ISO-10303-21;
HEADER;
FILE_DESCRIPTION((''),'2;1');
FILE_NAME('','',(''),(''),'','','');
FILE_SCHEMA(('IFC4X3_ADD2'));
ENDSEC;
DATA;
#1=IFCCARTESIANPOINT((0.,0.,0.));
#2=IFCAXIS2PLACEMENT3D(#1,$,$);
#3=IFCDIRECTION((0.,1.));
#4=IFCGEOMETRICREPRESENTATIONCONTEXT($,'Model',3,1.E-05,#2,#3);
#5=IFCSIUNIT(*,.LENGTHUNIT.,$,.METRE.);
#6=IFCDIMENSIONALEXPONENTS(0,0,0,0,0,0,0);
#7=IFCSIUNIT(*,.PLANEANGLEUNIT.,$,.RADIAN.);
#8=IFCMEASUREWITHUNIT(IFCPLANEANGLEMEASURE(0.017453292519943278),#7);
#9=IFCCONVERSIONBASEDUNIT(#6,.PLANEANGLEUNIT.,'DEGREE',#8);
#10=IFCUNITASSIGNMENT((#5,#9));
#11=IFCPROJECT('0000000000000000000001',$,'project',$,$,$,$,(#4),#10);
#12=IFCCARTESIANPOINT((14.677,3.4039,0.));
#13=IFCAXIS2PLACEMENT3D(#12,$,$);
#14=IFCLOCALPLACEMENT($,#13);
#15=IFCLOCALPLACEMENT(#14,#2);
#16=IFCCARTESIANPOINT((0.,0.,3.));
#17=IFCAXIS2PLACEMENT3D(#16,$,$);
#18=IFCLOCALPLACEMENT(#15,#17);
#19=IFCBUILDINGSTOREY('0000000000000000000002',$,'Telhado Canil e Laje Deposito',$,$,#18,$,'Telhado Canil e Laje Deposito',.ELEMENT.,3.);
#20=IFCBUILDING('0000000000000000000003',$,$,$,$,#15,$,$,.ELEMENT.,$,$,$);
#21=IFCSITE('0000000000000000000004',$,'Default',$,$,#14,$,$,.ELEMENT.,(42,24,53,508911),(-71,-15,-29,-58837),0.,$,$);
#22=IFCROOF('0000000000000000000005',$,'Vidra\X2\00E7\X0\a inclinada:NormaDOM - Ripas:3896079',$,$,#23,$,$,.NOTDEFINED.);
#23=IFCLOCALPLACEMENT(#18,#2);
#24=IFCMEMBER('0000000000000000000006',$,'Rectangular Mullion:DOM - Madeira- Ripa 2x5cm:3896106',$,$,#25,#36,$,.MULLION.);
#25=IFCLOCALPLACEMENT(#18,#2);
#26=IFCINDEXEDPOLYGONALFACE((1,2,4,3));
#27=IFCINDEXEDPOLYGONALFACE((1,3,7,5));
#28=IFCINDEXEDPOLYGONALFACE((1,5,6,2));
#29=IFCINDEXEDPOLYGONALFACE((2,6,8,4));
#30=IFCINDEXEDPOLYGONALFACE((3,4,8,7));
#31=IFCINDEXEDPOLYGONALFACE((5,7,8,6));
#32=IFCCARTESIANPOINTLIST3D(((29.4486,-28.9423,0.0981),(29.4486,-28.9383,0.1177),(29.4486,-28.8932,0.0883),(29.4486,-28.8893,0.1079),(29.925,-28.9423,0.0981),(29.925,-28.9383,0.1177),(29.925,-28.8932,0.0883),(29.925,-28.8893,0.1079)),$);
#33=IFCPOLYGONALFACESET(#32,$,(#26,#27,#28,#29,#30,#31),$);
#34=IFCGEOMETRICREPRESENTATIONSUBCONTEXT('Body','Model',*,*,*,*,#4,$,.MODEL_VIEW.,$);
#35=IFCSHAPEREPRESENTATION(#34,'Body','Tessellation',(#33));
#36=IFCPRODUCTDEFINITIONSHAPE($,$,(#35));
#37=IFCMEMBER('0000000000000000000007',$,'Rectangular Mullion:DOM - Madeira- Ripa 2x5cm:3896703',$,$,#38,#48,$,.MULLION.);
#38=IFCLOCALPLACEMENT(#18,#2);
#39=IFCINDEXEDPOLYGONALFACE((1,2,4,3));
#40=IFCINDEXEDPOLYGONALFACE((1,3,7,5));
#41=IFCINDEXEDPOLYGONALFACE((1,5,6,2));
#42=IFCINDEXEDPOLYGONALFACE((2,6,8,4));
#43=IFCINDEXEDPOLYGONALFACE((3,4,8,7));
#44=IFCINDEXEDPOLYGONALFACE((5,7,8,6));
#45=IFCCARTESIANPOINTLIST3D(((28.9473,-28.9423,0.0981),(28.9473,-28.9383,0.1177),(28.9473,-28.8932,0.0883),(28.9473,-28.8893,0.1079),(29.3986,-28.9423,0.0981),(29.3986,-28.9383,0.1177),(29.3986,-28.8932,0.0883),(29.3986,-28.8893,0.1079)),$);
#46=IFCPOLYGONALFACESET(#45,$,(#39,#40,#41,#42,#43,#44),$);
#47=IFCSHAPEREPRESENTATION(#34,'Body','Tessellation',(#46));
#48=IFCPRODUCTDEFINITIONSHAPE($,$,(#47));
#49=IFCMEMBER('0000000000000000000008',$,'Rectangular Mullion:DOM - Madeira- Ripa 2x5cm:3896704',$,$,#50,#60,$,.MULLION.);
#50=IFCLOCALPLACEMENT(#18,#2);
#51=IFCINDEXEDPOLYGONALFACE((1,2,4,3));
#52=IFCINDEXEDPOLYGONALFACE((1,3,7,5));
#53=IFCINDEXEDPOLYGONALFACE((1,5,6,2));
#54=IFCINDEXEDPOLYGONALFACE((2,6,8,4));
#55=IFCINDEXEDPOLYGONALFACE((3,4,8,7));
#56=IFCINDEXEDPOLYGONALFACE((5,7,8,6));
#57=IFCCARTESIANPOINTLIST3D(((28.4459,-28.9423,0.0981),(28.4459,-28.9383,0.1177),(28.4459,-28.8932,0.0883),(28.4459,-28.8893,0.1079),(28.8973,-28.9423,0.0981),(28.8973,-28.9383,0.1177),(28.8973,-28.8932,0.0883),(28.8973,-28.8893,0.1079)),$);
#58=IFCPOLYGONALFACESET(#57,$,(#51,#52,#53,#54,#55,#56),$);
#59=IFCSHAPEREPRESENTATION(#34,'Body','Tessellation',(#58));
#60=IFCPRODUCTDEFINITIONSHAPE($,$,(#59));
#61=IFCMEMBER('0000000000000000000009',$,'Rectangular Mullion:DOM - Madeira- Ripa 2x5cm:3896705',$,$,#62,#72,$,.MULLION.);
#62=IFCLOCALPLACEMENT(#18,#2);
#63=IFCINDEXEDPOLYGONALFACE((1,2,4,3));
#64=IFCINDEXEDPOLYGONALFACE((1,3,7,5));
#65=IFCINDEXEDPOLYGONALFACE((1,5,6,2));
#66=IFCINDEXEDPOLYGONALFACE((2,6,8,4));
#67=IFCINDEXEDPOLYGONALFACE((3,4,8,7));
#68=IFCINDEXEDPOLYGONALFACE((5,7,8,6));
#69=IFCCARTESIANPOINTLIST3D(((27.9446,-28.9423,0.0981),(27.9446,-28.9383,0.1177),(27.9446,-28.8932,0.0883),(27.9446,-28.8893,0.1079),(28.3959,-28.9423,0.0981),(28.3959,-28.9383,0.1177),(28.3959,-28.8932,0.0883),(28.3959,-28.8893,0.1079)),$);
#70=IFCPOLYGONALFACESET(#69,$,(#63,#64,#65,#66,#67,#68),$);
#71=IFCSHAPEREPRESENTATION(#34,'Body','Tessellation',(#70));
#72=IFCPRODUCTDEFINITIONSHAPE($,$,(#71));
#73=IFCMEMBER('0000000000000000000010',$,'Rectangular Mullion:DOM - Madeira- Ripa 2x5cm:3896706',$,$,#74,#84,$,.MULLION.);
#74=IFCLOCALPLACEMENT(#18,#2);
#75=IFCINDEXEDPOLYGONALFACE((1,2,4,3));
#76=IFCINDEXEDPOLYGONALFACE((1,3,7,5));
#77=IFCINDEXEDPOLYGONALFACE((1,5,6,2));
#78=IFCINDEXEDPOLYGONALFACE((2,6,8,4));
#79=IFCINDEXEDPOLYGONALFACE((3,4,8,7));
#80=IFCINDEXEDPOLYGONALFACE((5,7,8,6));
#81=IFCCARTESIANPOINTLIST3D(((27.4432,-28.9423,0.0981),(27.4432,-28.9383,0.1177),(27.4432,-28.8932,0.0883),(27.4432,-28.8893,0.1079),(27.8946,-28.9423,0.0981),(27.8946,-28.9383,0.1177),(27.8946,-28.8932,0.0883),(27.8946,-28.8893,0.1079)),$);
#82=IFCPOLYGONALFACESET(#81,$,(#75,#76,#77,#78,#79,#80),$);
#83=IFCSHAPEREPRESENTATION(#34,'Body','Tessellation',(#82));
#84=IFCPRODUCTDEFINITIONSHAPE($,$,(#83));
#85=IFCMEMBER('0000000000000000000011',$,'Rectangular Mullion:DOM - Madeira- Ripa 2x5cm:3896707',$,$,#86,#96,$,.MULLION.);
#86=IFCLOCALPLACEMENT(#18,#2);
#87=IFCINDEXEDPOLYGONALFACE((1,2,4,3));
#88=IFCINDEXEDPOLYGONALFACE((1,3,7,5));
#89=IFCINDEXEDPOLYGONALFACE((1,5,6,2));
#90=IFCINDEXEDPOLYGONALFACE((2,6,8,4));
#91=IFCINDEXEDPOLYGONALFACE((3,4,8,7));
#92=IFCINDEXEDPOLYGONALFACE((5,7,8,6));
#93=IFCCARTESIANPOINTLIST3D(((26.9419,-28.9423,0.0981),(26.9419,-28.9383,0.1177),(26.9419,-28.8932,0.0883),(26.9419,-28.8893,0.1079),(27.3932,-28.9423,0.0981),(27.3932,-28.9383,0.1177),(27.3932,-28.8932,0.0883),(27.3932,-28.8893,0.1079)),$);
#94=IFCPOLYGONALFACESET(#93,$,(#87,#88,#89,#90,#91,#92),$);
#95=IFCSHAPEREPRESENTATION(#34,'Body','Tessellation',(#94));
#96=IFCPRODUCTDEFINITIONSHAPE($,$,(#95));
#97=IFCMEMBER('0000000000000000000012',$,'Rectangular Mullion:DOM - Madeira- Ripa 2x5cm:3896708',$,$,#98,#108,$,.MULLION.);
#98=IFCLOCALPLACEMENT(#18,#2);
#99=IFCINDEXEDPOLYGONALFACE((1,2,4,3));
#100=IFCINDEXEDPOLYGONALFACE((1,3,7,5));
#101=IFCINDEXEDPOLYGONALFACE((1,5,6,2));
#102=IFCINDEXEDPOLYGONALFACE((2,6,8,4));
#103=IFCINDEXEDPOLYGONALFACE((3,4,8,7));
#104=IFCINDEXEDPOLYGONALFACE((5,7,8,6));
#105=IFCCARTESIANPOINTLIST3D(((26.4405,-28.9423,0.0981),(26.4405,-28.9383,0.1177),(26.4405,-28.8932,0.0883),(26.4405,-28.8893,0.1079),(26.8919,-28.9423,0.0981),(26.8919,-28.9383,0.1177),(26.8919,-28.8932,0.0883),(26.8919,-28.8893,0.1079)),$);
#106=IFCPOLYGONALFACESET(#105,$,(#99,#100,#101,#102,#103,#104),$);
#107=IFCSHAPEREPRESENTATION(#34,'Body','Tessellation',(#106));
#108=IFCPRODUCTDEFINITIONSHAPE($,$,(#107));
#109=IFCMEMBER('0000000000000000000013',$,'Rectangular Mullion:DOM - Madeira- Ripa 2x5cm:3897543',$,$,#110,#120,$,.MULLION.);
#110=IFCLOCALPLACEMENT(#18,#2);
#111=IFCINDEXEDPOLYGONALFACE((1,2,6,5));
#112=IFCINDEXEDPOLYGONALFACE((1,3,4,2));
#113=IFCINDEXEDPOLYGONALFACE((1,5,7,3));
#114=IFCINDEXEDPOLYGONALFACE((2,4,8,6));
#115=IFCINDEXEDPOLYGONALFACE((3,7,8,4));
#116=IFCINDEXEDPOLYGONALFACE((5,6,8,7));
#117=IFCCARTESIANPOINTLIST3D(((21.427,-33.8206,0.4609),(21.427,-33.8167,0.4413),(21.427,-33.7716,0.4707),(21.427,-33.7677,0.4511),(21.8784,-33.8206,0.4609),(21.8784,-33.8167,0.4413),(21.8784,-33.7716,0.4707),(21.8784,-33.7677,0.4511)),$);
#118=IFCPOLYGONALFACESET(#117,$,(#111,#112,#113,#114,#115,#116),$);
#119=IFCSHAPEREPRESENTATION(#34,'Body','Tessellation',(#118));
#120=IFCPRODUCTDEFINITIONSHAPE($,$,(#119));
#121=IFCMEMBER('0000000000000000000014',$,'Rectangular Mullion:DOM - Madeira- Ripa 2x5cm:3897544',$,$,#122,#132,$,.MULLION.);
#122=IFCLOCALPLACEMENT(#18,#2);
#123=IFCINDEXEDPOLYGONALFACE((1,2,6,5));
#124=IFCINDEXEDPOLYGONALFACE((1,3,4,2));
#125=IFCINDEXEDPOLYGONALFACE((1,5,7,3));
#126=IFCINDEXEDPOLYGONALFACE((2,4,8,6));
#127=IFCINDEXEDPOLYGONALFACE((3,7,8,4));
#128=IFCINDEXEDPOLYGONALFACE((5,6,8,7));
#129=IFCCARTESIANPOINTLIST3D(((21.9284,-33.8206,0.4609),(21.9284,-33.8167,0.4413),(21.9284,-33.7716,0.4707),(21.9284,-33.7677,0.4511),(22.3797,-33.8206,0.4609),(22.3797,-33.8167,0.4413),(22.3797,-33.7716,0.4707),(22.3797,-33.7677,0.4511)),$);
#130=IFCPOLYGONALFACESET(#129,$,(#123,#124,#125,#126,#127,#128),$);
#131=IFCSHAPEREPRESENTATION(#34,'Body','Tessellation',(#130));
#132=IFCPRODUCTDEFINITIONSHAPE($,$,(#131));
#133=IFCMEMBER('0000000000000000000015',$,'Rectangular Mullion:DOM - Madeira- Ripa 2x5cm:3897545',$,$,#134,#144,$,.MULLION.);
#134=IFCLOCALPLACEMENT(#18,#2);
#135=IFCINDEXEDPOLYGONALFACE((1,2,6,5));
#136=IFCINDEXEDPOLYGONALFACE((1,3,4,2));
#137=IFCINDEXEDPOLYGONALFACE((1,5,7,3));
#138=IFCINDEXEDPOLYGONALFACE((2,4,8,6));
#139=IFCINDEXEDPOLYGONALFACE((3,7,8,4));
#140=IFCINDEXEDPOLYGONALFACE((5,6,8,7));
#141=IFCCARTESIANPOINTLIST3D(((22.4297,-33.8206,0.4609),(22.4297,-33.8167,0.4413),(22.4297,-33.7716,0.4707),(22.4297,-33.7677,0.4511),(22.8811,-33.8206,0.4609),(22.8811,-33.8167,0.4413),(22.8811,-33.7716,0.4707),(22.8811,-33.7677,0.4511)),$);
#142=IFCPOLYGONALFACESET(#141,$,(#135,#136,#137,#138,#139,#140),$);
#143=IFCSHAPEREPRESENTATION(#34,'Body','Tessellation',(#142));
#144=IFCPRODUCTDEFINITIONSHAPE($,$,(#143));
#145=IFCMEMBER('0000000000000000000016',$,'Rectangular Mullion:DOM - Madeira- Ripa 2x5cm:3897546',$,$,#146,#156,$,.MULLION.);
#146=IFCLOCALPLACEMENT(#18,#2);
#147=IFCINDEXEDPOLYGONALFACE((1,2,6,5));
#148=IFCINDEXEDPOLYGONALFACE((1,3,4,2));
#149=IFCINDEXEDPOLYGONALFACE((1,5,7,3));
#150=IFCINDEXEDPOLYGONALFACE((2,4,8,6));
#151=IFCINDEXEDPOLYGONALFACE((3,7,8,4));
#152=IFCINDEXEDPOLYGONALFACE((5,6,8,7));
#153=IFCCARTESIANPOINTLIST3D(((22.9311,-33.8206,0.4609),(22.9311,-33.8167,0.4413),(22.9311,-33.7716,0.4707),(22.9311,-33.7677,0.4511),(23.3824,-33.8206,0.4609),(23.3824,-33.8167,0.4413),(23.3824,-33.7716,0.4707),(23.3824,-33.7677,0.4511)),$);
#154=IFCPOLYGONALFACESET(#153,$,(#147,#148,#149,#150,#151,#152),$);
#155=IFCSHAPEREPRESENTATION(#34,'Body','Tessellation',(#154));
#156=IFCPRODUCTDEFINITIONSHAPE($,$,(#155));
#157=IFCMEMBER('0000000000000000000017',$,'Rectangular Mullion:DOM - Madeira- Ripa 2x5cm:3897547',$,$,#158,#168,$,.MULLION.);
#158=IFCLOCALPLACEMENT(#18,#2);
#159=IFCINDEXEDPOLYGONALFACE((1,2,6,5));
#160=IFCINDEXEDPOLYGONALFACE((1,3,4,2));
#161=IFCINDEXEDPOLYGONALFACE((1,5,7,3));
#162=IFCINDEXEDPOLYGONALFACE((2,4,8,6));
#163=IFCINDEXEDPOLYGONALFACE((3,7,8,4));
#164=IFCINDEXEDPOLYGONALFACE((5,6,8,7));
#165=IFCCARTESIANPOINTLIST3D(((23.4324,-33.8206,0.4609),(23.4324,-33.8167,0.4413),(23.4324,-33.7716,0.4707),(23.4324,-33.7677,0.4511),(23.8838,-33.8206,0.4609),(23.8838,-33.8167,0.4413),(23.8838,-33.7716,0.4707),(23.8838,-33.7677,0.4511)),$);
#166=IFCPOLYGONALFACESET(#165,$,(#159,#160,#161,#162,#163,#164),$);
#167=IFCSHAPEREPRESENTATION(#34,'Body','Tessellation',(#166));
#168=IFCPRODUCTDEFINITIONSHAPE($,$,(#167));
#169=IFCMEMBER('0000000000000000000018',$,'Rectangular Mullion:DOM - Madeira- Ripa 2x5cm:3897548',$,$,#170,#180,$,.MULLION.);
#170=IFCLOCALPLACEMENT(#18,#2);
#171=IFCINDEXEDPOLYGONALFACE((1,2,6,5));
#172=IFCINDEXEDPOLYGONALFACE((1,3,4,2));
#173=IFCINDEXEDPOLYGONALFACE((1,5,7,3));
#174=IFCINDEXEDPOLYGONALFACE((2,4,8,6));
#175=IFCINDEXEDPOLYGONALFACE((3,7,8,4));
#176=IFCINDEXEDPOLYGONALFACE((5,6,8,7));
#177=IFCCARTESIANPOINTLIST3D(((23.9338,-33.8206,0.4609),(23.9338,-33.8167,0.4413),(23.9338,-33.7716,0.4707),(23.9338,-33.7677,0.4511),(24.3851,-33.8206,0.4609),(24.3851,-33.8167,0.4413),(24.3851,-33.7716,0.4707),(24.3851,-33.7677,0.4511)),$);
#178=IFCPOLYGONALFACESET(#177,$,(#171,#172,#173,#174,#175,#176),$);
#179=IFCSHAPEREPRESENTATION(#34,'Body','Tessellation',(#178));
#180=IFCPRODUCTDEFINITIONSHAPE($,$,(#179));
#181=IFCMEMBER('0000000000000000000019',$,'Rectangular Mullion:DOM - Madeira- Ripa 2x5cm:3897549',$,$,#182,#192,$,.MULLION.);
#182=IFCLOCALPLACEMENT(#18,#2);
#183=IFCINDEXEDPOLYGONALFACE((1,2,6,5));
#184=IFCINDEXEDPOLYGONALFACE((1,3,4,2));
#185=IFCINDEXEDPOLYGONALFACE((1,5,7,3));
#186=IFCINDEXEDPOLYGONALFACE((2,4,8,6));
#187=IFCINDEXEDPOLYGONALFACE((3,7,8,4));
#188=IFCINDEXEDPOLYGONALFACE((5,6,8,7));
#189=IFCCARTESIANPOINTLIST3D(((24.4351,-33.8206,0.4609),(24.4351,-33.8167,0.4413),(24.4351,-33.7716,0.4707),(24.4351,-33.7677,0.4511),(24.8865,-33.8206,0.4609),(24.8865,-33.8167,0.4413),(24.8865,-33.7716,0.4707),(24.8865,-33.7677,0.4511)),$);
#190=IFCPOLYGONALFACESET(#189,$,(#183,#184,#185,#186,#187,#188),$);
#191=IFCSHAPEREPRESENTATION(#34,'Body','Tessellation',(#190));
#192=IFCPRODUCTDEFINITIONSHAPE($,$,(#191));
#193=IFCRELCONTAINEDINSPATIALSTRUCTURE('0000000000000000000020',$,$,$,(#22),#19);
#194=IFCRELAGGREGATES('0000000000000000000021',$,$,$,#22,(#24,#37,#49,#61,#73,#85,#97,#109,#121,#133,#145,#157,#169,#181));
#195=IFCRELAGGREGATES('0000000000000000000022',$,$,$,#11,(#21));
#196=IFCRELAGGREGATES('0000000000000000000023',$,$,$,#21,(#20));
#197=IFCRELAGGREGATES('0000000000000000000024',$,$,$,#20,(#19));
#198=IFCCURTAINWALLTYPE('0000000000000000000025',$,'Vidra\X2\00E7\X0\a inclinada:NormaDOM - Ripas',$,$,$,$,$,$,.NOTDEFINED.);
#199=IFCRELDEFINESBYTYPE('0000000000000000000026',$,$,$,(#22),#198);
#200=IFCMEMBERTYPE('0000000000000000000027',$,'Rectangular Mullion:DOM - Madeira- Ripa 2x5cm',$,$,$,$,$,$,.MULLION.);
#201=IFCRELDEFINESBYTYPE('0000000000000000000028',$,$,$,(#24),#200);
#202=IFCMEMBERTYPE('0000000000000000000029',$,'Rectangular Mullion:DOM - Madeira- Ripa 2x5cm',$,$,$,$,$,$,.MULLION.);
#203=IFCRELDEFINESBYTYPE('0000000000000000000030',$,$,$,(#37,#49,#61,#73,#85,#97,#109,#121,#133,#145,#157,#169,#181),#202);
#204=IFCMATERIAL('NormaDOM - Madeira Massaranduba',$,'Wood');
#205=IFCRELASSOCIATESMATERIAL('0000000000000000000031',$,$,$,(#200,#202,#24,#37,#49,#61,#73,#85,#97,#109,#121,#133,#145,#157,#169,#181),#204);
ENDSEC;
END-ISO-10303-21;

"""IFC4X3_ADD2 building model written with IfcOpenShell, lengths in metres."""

from ifc_helpers import new_model, entity, si_unit, converted_unit, direction, frame, origin, origin_2d_with_axis, place, context, subcontext, project, spatial, rectangle, extrude, source, transform, mapped, material, material_profile, profile_set, profile_usage, type_object, type_shapes, element, aggregate, save


model = new_model("IFC4X3_ADD2")

# Units and contexts
model_context = context("Model", 3, precision=1e-05, world=origin(), true_north=direction((0.0, 1.0)))
body_context = subcontext(model_context, "Body", "Model", "MODEL_VIEW")
ifc_project = project(units=[si_unit("LENGTHUNIT", "METRE"), converted_unit("PLANEANGLEUNIT", "DEGREE", entity("IfcPlaneAngleMeasure", 0.017453292519943278), si_unit("PLANEANGLEUNIT", "RADIAN"), dimensions=[0, 0, 0, 0, 0, 0, 0])], contexts=[model_context])

# Site, building, storey
site_placement = place(None, frame((14.677, 3.4039, 0.0)))
site = spatial("IfcSite", under=ifc_project, at=site_placement, Name="Default", CompositionType="ELEMENT", RefLatitude=(42, 24, 53, 508911), RefLongitude=(-71, -15, -29, -58837), RefElevation=0.0)
building_placement = place(site_placement, origin())
building = spatial("IfcBuilding", under=site, at=building_placement, CompositionType="ELEMENT")
storey_placement = place(building_placement, frame((0.0, 0.0, 3.0)))
storey = spatial("IfcBuildingStorey", under=building, at=storey_placement, Name="Telhado Canil e Laje Deposito", LongName="Telhado Canil e Laje Deposito", CompositionType="ELEMENT", Elevation=3.0)

# Roof, members
curtain_wall_type = type_object("IfcCurtainWallType", Name="Vidraça inclinada:NormaDOM - Ripas", PredefinedType="NOTDEFINED")
roof_placement = place(storey_placement, frame((0.0, 0.0, -3.0)))
roof = element("IfcRoof", 1, at=roof_placement, inside=storey, type_object=curtain_wall_type, Name="Vidraça inclinada:NormaDOM - Ripas:3896079", PredefinedType="NOTDEFINED")
ifc_material = material(Name="NormaDOM - Madeira Massaranduba", Category="Wood")
ifc_material_profile_1 = material_profile(ifc_material, rectangle(XDim=0.05, YDim=0.02, at=origin_2d_with_axis()), Name="DOM - Madeira- Ripa 2x5cm")
ifc_profile_set_1 = profile_set([ifc_material_profile_1], Name="DOM - Madeira- Ripa 2x5cm")
ifc_profile_usage_1 = profile_usage(ifc_profile_set_1)
member_type_1 = type_object("IfcMemberType", Name="Rectangular Mullion:DOM - Madeira- Ripa 2x5cm", PredefinedType="MULLION", material=ifc_profile_set_1)
shared_shape_1 = source(origin(), body_context, "Body", "SweptSolid", [
    extrude(rectangle(XDim=0.05, YDim=0.02, at=origin_2d_with_axis()), frame((0.025, 0.01, -0.4764), z_axis=(0.0, 0.0, 1.0), x_axis=(-1.0, 0.0, 0.0)), (0.0, 0.0, 1.0), 0.4764),
])
type_shapes(member_type_1, [shared_shape_1])
member_1_placement = place(roof_placement, frame((29.925, -28.8893, 3.1079), z_axis=(1.0, 0.0, 0.0), x_axis=(0.0, -0.980581, 0.196116)))
member_1 = element("IfcMember", 2, at=member_1_placement, type_object=member_type_1, material=ifc_profile_usage_1, Name="Rectangular Mullion:DOM - Madeira- Ripa 2x5cm:3896106", PredefinedType="MULLION", context=body_context, shape_type="MappedRepresentation", body=[
    mapped(shared_shape_1, transform((0.0, 0.0, 0.0), scale=1.0)),
])
member_type_2 = type_object("IfcMemberType", Name="Rectangular Mullion:DOM - Madeira- Ripa 2x5cm", PredefinedType="MULLION", material=ifc_profile_set_1)
shared_shape_2 = source(origin(), body_context, "Body", "SweptSolid", [
    extrude(rectangle(XDim=0.05, YDim=0.02, at=origin_2d_with_axis()), frame((0.025, 0.01, -0.4514), z_axis=(0.0, 0.0, 1.0), x_axis=(-1.0, 0.0, 0.0)), (0.0, 0.0, 1.0), 0.4514),
])
type_shapes(member_type_2, [shared_shape_2])
member_2_placement = place(roof_placement, frame((29.3986, -28.8893, 3.1079), z_axis=(1.0, 0.0, 0.0), x_axis=(0.0, -0.980581, 0.196116)))
member_2 = element("IfcMember", 3, at=member_2_placement, type_object=member_type_2, material=ifc_profile_usage_1, Name="Rectangular Mullion:DOM - Madeira- Ripa 2x5cm:3896703", PredefinedType="MULLION", context=body_context, shape_type="MappedRepresentation", body=[
    mapped(shared_shape_2, transform((0.0, 0.0, 0.0), scale=1.0)),
])
member_3_placement = place(roof_placement, frame((28.8973, -28.8893, 3.1079), z_axis=(1.0, 0.0, 0.0), x_axis=(0.0, -0.980581, 0.196116)))
member_3 = element("IfcMember", 4, at=member_3_placement, type_object=member_type_2, material=ifc_profile_usage_1, Name="Rectangular Mullion:DOM - Madeira- Ripa 2x5cm:3896704", PredefinedType="MULLION", context=body_context, shape_type="MappedRepresentation", body=[
    mapped(shared_shape_2, transform((0.0, 0.0, 0.0), scale=1.0)),
])
member_4_placement = place(roof_placement, frame((28.3959, -28.8893, 3.1079), z_axis=(1.0, 0.0, 0.0), x_axis=(0.0, -0.980581, 0.196116)))
member_4 = element("IfcMember", 5, at=member_4_placement, type_object=member_type_2, material=ifc_profile_usage_1, Name="Rectangular Mullion:DOM - Madeira- Ripa 2x5cm:3896705", PredefinedType="MULLION", context=body_context, shape_type="MappedRepresentation", body=[
    mapped(shared_shape_2, transform((0.0, 0.0, 0.0), scale=1.0)),
])
member_5_placement = place(roof_placement, frame((27.8946, -28.8893, 3.1079), z_axis=(1.0, 0.0, 0.0), x_axis=(0.0, -0.980581, 0.196116)))
member_5 = element("IfcMember", 6, at=member_5_placement, type_object=member_type_2, material=ifc_profile_usage_1, Name="Rectangular Mullion:DOM - Madeira- Ripa 2x5cm:3896706", PredefinedType="MULLION", context=body_context, shape_type="MappedRepresentation", body=[
    mapped(shared_shape_2, transform((0.0, 0.0, 0.0), scale=1.0)),
])
member_6_placement = place(roof_placement, frame((27.3932, -28.8893, 3.1079), z_axis=(1.0, 0.0, 0.0), x_axis=(0.0, -0.980581, 0.196116)))
member_6 = element("IfcMember", 7, at=member_6_placement, type_object=member_type_2, material=ifc_profile_usage_1, Name="Rectangular Mullion:DOM - Madeira- Ripa 2x5cm:3896707", PredefinedType="MULLION", context=body_context, shape_type="MappedRepresentation", body=[
    mapped(shared_shape_2, transform((0.0, 0.0, 0.0), scale=1.0)),
])
member_7_placement = place(roof_placement, frame((26.8919, -28.8893, 3.1079), z_axis=(1.0, 0.0, 0.0), x_axis=(0.0, -0.980581, 0.196116)))
member_7 = element("IfcMember", 8, at=member_7_placement, type_object=member_type_2, material=ifc_profile_usage_1, Name="Rectangular Mullion:DOM - Madeira- Ripa 2x5cm:3896708", PredefinedType="MULLION", context=body_context, shape_type="MappedRepresentation", body=[
    mapped(shared_shape_2, transform((0.0, 0.0, 0.0), scale=1.0)),
])
member_8_placement = place(roof_placement, frame((21.427, -33.8206, 3.4609), z_axis=(-1.0, 0.0, 0.0), x_axis=(0.0, 0.980581, 0.196116)))
member_8 = element("IfcMember", 9, at=member_8_placement, type_object=member_type_2, material=ifc_profile_usage_1, Name="Rectangular Mullion:DOM - Madeira- Ripa 2x5cm:3897543", PredefinedType="MULLION", context=body_context, shape_type="MappedRepresentation", body=[
    mapped(shared_shape_2, transform((0.0, 0.0, 0.0), scale=1.0)),
])
member_9_placement = place(roof_placement, frame((21.9284, -33.8206, 3.4609), z_axis=(-1.0, 0.0, 0.0), x_axis=(0.0, 0.980581, 0.196116)))
member_9 = element("IfcMember", 10, at=member_9_placement, type_object=member_type_2, material=ifc_profile_usage_1, Name="Rectangular Mullion:DOM - Madeira- Ripa 2x5cm:3897544", PredefinedType="MULLION", context=body_context, shape_type="MappedRepresentation", body=[
    mapped(shared_shape_2, transform((0.0, 0.0, 0.0), scale=1.0)),
])
member_10_placement = place(roof_placement, frame((22.4297, -33.8206, 3.4609), z_axis=(-1.0, 0.0, 0.0), x_axis=(0.0, 0.980581, 0.196116)))
member_10 = element("IfcMember", 11, at=member_10_placement, type_object=member_type_2, material=ifc_profile_usage_1, Name="Rectangular Mullion:DOM - Madeira- Ripa 2x5cm:3897545", PredefinedType="MULLION", context=body_context, shape_type="MappedRepresentation", body=[
    mapped(shared_shape_2, transform((0.0, 0.0, 0.0), scale=1.0)),
])
member_11_placement = place(roof_placement, frame((22.9311, -33.8206, 3.4609), z_axis=(-1.0, 0.0, 0.0), x_axis=(0.0, 0.980581, 0.196116)))
member_11 = element("IfcMember", 12, at=member_11_placement, type_object=member_type_2, material=ifc_profile_usage_1, Name="Rectangular Mullion:DOM - Madeira- Ripa 2x5cm:3897546", PredefinedType="MULLION", context=body_context, shape_type="MappedRepresentation", body=[
    mapped(shared_shape_2, transform((0.0, 0.0, 0.0), scale=1.0)),
])
member_12_placement = place(roof_placement, frame((23.4324, -33.8206, 3.4609), z_axis=(-1.0, 0.0, 0.0), x_axis=(0.0, 0.980581, 0.196116)))
member_12 = element("IfcMember", 13, at=member_12_placement, type_object=member_type_2, material=ifc_profile_usage_1, Name="Rectangular Mullion:DOM - Madeira- Ripa 2x5cm:3897547", PredefinedType="MULLION", context=body_context, shape_type="MappedRepresentation", body=[
    mapped(shared_shape_2, transform((0.0, 0.0, 0.0), scale=1.0)),
])
member_13_placement = place(roof_placement, frame((23.9338, -33.8206, 3.4609), z_axis=(-1.0, 0.0, 0.0), x_axis=(0.0, 0.980581, 0.196116)))
member_13 = element("IfcMember", 14, at=member_13_placement, type_object=member_type_2, material=ifc_profile_usage_1, Name="Rectangular Mullion:DOM - Madeira- Ripa 2x5cm:3897548", PredefinedType="MULLION", context=body_context, shape_type="MappedRepresentation", body=[
    mapped(shared_shape_2, transform((0.0, 0.0, 0.0), scale=1.0)),
])
member_14_placement = place(roof_placement, frame((24.4351, -33.8206, 3.4609), z_axis=(-1.0, 0.0, 0.0), x_axis=(0.0, 0.980581, 0.196116)))
member_14 = element("IfcMember", 15, at=member_14_placement, type_object=member_type_2, material=ifc_profile_usage_1, Name="Rectangular Mullion:DOM - Madeira- Ripa 2x5cm:3897549", PredefinedType="MULLION", context=body_context, shape_type="MappedRepresentation", body=[
    mapped(shared_shape_2, transform((0.0, 0.0, 0.0), scale=1.0)),
])
aggregate(roof, [member_1, member_2, member_3, member_4, member_5, member_6, member_7, member_8, member_9, member_10, member_11, member_12, member_13, member_14])

save(model, "model.ifc")
